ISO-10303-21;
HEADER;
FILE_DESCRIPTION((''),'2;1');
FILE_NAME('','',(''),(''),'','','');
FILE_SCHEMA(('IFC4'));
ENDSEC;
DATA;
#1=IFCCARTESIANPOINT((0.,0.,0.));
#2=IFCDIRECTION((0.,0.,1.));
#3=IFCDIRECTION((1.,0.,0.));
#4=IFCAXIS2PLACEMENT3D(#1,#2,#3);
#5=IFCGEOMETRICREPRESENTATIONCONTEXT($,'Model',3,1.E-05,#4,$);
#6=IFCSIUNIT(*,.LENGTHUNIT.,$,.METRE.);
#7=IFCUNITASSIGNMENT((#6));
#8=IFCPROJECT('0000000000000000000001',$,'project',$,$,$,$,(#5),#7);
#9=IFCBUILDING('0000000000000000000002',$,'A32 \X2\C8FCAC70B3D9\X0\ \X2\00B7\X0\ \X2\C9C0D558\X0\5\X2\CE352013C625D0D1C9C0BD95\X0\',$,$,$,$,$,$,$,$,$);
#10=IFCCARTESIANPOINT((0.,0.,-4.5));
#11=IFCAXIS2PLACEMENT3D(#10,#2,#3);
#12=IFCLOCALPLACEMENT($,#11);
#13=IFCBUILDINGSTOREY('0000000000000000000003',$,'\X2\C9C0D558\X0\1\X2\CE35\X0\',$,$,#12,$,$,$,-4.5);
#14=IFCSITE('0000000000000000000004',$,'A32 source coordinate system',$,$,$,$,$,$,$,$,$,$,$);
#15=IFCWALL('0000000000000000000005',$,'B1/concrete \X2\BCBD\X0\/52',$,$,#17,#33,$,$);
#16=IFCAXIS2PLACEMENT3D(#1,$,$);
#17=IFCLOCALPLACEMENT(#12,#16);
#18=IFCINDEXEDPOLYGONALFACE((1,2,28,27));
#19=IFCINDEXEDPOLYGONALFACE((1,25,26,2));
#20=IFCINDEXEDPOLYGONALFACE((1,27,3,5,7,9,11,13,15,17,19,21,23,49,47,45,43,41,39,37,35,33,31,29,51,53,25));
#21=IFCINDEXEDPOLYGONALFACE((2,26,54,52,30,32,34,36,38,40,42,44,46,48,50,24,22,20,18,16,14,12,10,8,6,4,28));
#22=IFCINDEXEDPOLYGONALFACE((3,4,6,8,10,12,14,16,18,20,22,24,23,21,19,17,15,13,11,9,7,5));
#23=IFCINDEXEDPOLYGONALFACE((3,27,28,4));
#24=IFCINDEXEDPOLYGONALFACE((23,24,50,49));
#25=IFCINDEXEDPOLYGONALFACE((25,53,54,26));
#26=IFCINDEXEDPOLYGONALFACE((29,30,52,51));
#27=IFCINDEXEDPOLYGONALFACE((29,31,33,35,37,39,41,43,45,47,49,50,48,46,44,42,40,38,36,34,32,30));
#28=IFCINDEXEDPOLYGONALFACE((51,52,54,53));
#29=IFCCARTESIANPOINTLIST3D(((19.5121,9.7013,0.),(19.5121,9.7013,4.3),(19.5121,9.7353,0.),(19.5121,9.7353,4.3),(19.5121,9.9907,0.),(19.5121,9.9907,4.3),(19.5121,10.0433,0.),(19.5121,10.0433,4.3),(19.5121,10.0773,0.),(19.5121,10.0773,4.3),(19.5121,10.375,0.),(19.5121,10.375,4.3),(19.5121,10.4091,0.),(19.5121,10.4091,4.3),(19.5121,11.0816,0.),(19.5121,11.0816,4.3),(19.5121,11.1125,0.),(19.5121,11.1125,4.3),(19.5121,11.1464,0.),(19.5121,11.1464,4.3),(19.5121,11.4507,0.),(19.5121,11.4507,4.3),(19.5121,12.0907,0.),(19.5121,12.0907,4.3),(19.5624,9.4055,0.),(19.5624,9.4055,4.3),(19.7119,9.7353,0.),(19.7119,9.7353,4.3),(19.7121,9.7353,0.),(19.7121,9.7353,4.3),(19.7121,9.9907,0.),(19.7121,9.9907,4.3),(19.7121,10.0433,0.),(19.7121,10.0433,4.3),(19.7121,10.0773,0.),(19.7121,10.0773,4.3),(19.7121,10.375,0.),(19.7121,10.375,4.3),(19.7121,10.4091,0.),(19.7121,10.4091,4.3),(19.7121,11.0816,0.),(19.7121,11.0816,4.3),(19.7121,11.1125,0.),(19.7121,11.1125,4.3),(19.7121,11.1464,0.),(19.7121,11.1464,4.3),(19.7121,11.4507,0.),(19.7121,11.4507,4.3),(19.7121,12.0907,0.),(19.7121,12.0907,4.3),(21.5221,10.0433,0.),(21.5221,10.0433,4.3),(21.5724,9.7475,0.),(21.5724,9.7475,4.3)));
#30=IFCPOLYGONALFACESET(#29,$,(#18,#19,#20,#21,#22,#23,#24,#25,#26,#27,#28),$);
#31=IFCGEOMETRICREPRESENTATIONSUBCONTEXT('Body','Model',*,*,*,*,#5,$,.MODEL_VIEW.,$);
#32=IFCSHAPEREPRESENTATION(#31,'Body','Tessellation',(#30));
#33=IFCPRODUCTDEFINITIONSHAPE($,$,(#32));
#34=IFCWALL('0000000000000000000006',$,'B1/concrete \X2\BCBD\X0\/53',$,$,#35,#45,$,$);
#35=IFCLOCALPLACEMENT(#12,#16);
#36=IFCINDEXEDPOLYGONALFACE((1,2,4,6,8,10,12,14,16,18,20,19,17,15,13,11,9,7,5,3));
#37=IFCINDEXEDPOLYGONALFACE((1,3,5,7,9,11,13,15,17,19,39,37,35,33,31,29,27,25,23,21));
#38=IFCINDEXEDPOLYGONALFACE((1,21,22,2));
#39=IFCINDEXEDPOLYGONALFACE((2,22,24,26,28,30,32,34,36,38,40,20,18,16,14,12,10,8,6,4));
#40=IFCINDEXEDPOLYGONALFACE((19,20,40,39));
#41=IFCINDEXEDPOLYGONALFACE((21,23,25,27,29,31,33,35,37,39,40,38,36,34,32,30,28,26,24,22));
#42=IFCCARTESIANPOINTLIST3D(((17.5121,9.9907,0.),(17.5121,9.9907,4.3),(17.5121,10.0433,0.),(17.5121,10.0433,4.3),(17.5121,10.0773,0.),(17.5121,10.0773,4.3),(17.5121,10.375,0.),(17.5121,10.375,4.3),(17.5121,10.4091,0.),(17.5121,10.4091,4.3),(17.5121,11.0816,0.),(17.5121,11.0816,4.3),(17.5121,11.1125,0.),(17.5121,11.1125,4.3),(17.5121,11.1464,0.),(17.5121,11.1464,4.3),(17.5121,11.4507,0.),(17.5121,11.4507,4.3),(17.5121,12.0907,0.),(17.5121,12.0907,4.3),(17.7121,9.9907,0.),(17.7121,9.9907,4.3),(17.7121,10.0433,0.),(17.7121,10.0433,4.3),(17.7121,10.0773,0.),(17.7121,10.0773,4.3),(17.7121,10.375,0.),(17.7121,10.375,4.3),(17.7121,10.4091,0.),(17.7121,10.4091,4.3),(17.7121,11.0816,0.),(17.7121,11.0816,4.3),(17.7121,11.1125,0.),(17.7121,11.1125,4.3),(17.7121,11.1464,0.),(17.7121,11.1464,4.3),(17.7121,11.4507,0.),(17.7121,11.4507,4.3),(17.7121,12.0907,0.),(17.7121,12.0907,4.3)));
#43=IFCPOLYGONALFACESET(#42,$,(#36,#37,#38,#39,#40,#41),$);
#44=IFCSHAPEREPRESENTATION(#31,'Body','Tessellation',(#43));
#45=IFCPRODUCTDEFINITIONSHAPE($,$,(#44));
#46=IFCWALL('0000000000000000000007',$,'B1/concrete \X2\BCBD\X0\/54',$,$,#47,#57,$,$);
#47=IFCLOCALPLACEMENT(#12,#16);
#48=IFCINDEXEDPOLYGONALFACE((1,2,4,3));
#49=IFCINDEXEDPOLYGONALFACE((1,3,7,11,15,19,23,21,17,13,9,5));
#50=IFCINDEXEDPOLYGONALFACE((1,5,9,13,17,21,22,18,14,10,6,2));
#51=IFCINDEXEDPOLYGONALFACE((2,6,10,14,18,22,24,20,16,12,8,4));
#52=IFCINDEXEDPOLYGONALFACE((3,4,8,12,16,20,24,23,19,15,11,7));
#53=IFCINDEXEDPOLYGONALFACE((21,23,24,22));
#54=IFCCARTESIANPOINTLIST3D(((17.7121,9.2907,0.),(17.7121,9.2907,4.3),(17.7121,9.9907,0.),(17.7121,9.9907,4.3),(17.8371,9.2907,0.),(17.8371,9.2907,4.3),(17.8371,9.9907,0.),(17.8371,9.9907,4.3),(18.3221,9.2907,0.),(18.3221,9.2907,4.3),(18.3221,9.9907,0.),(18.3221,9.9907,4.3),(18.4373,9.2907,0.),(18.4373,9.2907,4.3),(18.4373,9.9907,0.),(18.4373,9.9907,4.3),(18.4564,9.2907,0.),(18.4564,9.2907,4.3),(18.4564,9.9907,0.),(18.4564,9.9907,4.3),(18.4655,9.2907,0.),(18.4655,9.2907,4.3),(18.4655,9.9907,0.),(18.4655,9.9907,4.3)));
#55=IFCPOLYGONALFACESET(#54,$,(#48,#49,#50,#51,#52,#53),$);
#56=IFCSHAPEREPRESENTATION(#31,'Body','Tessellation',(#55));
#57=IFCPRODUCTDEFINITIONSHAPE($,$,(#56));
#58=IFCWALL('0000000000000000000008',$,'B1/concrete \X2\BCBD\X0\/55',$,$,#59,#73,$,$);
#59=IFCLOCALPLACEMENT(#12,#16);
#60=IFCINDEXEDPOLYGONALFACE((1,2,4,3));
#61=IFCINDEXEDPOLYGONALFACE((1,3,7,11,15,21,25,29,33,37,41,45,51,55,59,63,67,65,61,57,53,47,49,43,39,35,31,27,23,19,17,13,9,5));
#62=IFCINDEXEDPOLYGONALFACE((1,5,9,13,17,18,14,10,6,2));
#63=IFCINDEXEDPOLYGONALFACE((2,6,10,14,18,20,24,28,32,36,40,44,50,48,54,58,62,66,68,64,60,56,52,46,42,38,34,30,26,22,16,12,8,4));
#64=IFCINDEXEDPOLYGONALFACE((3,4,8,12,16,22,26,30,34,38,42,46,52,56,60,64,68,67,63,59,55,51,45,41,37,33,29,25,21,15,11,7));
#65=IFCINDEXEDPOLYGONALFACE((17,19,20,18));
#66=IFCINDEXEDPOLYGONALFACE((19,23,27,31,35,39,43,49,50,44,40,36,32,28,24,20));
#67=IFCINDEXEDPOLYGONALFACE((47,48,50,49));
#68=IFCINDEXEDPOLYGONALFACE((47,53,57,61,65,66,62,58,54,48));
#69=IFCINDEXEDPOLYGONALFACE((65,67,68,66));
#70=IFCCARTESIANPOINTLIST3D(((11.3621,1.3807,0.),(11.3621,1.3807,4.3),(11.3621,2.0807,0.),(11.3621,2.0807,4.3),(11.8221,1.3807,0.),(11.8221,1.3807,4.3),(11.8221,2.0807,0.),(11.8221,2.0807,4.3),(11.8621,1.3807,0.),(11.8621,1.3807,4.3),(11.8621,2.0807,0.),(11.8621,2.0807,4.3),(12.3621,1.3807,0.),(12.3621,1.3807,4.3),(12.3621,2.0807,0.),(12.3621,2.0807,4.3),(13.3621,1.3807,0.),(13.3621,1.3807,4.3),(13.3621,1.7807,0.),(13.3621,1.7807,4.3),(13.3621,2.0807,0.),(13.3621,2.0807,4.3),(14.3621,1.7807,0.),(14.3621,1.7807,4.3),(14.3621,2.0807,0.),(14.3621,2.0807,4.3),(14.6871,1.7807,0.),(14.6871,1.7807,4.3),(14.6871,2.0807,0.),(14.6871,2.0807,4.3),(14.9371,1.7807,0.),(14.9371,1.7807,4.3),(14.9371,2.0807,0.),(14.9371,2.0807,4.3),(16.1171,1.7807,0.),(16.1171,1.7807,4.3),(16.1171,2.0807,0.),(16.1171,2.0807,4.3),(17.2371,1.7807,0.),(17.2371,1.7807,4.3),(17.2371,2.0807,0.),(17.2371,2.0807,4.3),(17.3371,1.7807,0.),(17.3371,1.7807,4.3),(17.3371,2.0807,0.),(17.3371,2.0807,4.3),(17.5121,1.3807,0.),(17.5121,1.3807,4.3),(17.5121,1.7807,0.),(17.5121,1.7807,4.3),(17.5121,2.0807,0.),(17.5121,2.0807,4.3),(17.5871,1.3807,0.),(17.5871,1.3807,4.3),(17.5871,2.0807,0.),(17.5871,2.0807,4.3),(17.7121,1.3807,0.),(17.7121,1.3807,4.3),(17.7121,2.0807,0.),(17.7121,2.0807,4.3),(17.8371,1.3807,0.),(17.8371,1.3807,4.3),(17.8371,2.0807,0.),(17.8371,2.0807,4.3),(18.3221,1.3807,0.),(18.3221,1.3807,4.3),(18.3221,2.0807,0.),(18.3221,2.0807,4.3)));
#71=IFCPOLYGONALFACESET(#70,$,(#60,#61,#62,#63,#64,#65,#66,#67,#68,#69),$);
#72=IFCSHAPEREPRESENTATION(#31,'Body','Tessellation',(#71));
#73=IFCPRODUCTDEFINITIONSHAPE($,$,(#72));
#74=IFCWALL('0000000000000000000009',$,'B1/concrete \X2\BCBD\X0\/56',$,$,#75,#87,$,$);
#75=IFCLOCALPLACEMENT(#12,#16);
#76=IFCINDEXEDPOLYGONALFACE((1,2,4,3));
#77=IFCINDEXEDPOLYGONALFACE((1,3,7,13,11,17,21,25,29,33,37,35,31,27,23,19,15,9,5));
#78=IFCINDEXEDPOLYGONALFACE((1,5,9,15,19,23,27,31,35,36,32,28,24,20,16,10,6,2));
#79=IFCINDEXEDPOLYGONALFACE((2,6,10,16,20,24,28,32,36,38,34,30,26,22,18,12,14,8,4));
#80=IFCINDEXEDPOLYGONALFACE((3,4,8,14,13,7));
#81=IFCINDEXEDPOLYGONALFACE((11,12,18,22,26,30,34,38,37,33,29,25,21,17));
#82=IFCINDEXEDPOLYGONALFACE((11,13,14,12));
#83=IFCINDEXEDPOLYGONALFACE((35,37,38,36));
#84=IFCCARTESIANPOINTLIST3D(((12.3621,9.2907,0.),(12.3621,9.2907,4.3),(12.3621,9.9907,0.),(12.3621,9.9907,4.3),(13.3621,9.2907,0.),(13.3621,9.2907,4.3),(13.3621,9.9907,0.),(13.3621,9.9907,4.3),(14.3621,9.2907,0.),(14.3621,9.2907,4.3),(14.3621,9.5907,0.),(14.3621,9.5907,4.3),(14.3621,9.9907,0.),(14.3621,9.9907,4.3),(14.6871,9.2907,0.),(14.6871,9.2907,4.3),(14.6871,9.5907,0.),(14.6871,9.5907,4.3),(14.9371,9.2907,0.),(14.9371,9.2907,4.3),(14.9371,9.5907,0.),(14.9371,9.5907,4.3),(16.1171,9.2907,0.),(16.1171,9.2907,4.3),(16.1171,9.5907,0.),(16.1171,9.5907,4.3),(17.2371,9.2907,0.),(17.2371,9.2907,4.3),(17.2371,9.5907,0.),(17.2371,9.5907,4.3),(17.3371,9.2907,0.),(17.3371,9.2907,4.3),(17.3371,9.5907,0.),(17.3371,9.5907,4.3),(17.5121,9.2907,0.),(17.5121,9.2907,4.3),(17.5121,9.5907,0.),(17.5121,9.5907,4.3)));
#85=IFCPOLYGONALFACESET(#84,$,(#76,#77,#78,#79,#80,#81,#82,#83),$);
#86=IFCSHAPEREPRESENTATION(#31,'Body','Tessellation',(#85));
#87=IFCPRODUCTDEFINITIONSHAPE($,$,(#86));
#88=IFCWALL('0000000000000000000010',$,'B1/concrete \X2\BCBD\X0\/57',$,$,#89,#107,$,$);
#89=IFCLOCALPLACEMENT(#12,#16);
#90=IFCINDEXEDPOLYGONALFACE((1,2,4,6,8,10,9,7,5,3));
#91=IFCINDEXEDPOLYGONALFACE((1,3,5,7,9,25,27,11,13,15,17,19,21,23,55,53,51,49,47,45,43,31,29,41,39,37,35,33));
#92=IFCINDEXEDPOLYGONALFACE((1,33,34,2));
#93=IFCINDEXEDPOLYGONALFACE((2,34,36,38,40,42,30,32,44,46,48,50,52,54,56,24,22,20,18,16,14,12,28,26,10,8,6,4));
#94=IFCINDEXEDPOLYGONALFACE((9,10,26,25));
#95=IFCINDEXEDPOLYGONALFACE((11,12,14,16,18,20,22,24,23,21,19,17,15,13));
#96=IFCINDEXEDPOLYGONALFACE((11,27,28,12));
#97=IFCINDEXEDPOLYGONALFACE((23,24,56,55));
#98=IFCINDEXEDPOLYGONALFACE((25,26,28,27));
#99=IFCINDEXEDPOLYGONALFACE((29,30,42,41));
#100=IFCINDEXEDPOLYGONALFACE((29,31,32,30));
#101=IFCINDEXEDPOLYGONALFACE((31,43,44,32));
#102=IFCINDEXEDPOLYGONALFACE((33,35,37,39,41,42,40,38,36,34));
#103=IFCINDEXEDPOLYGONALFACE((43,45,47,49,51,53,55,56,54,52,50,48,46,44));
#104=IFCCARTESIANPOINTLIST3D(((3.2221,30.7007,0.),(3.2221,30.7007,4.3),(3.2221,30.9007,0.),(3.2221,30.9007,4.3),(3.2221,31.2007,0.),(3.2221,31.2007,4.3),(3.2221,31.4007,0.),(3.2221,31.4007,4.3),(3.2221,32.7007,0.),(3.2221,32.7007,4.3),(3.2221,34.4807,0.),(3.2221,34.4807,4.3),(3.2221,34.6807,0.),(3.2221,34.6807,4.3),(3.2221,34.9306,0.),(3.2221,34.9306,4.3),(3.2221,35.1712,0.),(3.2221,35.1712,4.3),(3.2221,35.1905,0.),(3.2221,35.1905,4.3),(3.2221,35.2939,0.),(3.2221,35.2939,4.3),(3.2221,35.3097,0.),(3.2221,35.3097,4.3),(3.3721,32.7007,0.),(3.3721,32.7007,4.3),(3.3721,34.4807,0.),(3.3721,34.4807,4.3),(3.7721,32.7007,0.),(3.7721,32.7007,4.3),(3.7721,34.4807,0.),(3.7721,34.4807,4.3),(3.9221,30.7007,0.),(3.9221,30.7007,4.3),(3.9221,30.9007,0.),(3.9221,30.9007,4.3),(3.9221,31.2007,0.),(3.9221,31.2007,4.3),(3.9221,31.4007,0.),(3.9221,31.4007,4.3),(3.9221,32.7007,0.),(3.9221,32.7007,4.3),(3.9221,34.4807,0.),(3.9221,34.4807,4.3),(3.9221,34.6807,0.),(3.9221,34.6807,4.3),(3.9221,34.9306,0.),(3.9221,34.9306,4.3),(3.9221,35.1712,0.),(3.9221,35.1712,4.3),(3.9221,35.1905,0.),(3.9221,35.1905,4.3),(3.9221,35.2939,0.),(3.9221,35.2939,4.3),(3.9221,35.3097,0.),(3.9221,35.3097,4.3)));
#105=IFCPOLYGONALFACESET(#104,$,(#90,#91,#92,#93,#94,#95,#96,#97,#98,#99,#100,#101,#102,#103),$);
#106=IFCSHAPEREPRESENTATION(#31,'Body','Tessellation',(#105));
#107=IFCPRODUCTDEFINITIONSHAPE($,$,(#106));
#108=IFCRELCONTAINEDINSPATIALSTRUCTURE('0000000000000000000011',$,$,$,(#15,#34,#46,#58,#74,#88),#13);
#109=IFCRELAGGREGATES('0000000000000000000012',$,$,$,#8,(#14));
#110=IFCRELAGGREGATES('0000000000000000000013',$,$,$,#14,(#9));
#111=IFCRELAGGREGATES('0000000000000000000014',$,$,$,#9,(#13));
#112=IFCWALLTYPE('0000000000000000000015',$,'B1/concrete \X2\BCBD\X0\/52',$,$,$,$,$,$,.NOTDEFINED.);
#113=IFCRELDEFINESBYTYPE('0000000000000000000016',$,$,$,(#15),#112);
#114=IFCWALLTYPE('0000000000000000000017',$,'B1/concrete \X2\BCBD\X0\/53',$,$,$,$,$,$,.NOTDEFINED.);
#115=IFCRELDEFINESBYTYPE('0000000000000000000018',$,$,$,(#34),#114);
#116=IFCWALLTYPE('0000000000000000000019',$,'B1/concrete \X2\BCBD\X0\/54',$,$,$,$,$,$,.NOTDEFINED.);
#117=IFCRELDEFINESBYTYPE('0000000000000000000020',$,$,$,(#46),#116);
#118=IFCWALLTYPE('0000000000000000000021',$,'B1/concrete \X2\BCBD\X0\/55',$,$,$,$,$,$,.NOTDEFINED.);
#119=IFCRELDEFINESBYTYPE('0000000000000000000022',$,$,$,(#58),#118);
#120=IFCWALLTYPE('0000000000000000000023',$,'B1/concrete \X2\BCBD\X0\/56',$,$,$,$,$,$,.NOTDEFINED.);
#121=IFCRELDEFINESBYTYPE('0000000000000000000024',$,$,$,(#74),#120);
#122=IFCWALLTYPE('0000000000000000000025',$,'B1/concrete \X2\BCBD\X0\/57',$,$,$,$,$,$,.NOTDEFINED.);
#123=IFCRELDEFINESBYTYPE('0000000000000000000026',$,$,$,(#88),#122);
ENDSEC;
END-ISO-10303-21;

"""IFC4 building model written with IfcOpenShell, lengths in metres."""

from ifc_helpers import new_model, si_unit, frame, origin, origin_with_axes, place, context, subcontext, project, spatial, polyline, outline, extrude, source, transform, mapped, type_object, type_shapes, element, save


model = new_model("IFC4")

# Units and contexts
model_context = context("Model", 3, precision=1e-05, world=origin_with_axes())
body_context = subcontext(model_context, "Body", "Model", "MODEL_VIEW")
ifc_project = project(units=[si_unit("LENGTHUNIT", "METRE")], contexts=[model_context])

# Site, building, storey
site = spatial("IfcSite", under=ifc_project, Name="A32 source coordinate system")
building = spatial("IfcBuilding", under=site, Name="A32 주거동 · 지하5층–옥탑지붕")
storey_placement = place(None, frame((0.0, 0.0, -4.5), z_axis=(0.0, 0.0, 1.0), x_axis=(1.0, 0.0, 0.0)))
storey = spatial("IfcBuildingStorey", under=building, at=storey_placement, Name="지하1층", Elevation=-4.5)

# Walls
wall_type_1 = type_object("IfcWallType", Name="B1/concrete 벽/52", PredefinedType="NOTDEFINED")
shared_shape_1 = source(origin(), body_context, "Body", "SweptSolid", [
    extrude(outline(polyline([(19.7121, 12.0907), (19.7121, 11.4507), (19.7121, 11.1464), (19.7121, 11.1125), (19.7121, 11.0816), (19.7121, 10.4091), (19.7121, 10.375), (19.7121, 10.0773), (19.7121, 10.0433), (19.7121, 9.9907), (19.7121, 9.7353), (21.5221, 10.0433), (21.5724, 9.7475), (19.5624, 9.4055), (19.5121, 9.7013), (19.7119, 9.7353), (19.5121, 9.7353), (19.5121, 9.9907), (19.5121, 10.0433), (19.5121, 10.0773), (19.5121, 10.375), (19.5121, 10.4091), (19.5121, 11.0816), (19.5121, 11.1125), (19.5121, 11.1464), (19.5121, 11.4507), (19.5121, 12.0907), (19.7121, 12.0907)])), origin(), (0.0, 0.0, 1.0), 4.3),
])
type_shapes(wall_type_1, [shared_shape_1])
wall_1_placement = place(storey_placement, origin_with_axes())
element("IfcWall", 1, at=wall_1_placement, inside=storey, type_object=wall_type_1, Name="B1/concrete 벽/52", context=body_context, shape_type="MappedRepresentation", body=[
    mapped(shared_shape_1, transform((0.0, 0.0, 0.0), scale=1.0)),
])
wall_type_2 = type_object("IfcWallType", Name="B1/concrete 벽/53", PredefinedType="NOTDEFINED")
shared_shape_2 = source(origin(), body_context, "Body", "SweptSolid", [
    extrude(outline(polyline([(17.5121, 11.4507), (17.5121, 12.0907), (17.7121, 12.0907), (17.7121, 11.4507), (17.7121, 11.1464), (17.7121, 11.1125), (17.7121, 11.0816), (17.7121, 10.4091), (17.7121, 10.375), (17.7121, 10.0773), (17.7121, 10.0433), (17.7121, 9.9907), (17.5121, 9.9907), (17.5121, 10.0433), (17.5121, 10.0773), (17.5121, 10.375), (17.5121, 10.4091), (17.5121, 11.0816), (17.5121, 11.1125), (17.5121, 11.1464), (17.5121, 11.4507)])), origin(), (0.0, 0.0, 1.0), 4.3),
])
type_shapes(wall_type_2, [shared_shape_2])
wall_2_placement = place(storey_placement, origin_with_axes())
element("IfcWall", 2, at=wall_2_placement, inside=storey, type_object=wall_type_2, Name="B1/concrete 벽/53", context=body_context, shape_type="MappedRepresentation", body=[
    mapped(shared_shape_2, transform((0.0, 0.0, 0.0), scale=1.0)),
])
wall_type_3 = type_object("IfcWallType", Name="B1/concrete 벽/54", PredefinedType="NOTDEFINED")
shared_shape_3 = source(origin(), body_context, "Body", "SweptSolid", [
    extrude(outline(polyline([(18.4373, 9.9907), (18.4564, 9.9907), (18.4655, 9.9907), (18.4655, 9.2907), (18.4564, 9.2907), (18.4373, 9.2907), (18.3221, 9.2907), (17.8371, 9.2907), (17.7121, 9.2907), (17.7121, 9.9907), (17.8371, 9.9907), (18.3221, 9.9907), (18.4373, 9.9907)])), origin(), (0.0, 0.0, 1.0), 4.3),
])
type_shapes(wall_type_3, [shared_shape_3])
wall_3_placement = place(storey_placement, origin_with_axes())
element("IfcWall", 3, at=wall_3_placement, inside=storey, type_object=wall_type_3, Name="B1/concrete 벽/54", context=body_context, shape_type="MappedRepresentation", body=[
    mapped(shared_shape_3, transform((0.0, 0.0, 0.0), scale=1.0)),
])
wall_type_4 = type_object("IfcWallType", Name="B1/concrete 벽/55", PredefinedType="NOTDEFINED")
shared_shape_4 = source(origin(), body_context, "Body", "SweptSolid", [
    extrude(outline(polyline([(16.1171, 2.0807), (17.2371, 2.0807), (17.3371, 2.0807), (17.5121, 2.0807), (17.5871, 2.0807), (17.7121, 2.0807), (17.8371, 2.0807), (18.3221, 2.0807), (18.3221, 1.3807), (17.8371, 1.3807), (17.7121, 1.3807), (17.5871, 1.3807), (17.5121, 1.3807), (17.5121, 1.7807), (17.3371, 1.7807), (17.2371, 1.7807), (16.1171, 1.7807), (14.9371, 1.7807), (14.6871, 1.7807), (14.3621, 1.7807), (13.3621, 1.7807), (13.3621, 1.3807), (12.3621, 1.3807), (11.8621, 1.3807), (11.8221, 1.3807), (11.3621, 1.3807), (11.3621, 2.0807), (11.8221, 2.0807), (11.8621, 2.0807), (12.3621, 2.0807), (13.3621, 2.0807), (14.3621, 2.0807), (14.6871, 2.0807), (14.9371, 2.0807), (16.1171, 2.0807)])), origin(), (0.0, 0.0, 1.0), 4.3),
])
type_shapes(wall_type_4, [shared_shape_4])
wall_4_placement = place(storey_placement, origin_with_axes())
element("IfcWall", 4, at=wall_4_placement, inside=storey, type_object=wall_type_4, Name="B1/concrete 벽/55", context=body_context, shape_type="MappedRepresentation", body=[
    mapped(shared_shape_4, transform((0.0, 0.0, 0.0), scale=1.0)),
])
wall_type_5 = type_object("IfcWallType", Name="B1/concrete 벽/56", PredefinedType="NOTDEFINED")
shared_shape_5 = source(origin(), body_context, "Body", "SweptSolid", [
    extrude(outline(polyline([(16.1171, 9.5907), (17.2371, 9.5907), (17.3371, 9.5907), (17.5121, 9.5907), (17.5121, 9.2907), (17.3371, 9.2907), (17.2371, 9.2907), (16.1171, 9.2907), (14.9371, 9.2907), (14.6871, 9.2907), (14.3621, 9.2907), (13.3621, 9.2907), (12.3621, 9.2907), (12.3621, 9.9907), (13.3621, 9.9907), (14.3621, 9.9907), (14.3621, 9.5907), (14.6871, 9.5907), (14.9371, 9.5907), (16.1171, 9.5907)])), origin(), (0.0, 0.0, 1.0), 4.3),
])
type_shapes(wall_type_5, [shared_shape_5])
wall_5_placement = place(storey_placement, origin_with_axes())
element("IfcWall", 5, at=wall_5_placement, inside=storey, type_object=wall_type_5, Name="B1/concrete 벽/56", context=body_context, shape_type="MappedRepresentation", body=[
    mapped(shared_shape_5, transform((0.0, 0.0, 0.0), scale=1.0)),
])
wall_type_6 = type_object("IfcWallType", Name="B1/concrete 벽/57", PredefinedType="NOTDEFINED")
shared_shape_6 = source(origin(), body_context, "Body", "SweptSolid", [
    extrude(outline(polyline([(3.2221, 34.6807), (3.2221, 34.9306), (3.2221, 35.1712), (3.2221, 35.1905), (3.2221, 35.2939), (3.2221, 35.3097), (3.9221, 35.3097), (3.9221, 35.2939), (3.9221, 35.1905), (3.9221, 35.1712), (3.9221, 34.9306), (3.9221, 34.6807), (3.9221, 34.4807), (3.7721, 34.4807), (3.7721, 32.7007), (3.9221, 32.7007), (3.9221, 31.4007), (3.9221, 31.2007), (3.9221, 30.9007), (3.9221, 30.7007), (3.2221, 30.7007), (3.2221, 30.9007), (3.2221, 31.2007), (3.2221, 31.4007), (3.2221, 32.7007), (3.3721, 32.7007), (3.3721, 34.4807), (3.2221, 34.4807), (3.2221, 34.6807)])), origin(), (0.0, 0.0, 1.0), 4.3),
])
type_shapes(wall_type_6, [shared_shape_6])
wall_6_placement = place(storey_placement, origin_with_axes())
element("IfcWall", 6, at=wall_6_placement, inside=storey, type_object=wall_type_6, Name="B1/concrete 벽/57", context=body_context, shape_type="MappedRepresentation", body=[
    mapped(shared_shape_6, transform((0.0, 0.0, 0.0), scale=1.0)),
])

save(model, "model.ifc")
